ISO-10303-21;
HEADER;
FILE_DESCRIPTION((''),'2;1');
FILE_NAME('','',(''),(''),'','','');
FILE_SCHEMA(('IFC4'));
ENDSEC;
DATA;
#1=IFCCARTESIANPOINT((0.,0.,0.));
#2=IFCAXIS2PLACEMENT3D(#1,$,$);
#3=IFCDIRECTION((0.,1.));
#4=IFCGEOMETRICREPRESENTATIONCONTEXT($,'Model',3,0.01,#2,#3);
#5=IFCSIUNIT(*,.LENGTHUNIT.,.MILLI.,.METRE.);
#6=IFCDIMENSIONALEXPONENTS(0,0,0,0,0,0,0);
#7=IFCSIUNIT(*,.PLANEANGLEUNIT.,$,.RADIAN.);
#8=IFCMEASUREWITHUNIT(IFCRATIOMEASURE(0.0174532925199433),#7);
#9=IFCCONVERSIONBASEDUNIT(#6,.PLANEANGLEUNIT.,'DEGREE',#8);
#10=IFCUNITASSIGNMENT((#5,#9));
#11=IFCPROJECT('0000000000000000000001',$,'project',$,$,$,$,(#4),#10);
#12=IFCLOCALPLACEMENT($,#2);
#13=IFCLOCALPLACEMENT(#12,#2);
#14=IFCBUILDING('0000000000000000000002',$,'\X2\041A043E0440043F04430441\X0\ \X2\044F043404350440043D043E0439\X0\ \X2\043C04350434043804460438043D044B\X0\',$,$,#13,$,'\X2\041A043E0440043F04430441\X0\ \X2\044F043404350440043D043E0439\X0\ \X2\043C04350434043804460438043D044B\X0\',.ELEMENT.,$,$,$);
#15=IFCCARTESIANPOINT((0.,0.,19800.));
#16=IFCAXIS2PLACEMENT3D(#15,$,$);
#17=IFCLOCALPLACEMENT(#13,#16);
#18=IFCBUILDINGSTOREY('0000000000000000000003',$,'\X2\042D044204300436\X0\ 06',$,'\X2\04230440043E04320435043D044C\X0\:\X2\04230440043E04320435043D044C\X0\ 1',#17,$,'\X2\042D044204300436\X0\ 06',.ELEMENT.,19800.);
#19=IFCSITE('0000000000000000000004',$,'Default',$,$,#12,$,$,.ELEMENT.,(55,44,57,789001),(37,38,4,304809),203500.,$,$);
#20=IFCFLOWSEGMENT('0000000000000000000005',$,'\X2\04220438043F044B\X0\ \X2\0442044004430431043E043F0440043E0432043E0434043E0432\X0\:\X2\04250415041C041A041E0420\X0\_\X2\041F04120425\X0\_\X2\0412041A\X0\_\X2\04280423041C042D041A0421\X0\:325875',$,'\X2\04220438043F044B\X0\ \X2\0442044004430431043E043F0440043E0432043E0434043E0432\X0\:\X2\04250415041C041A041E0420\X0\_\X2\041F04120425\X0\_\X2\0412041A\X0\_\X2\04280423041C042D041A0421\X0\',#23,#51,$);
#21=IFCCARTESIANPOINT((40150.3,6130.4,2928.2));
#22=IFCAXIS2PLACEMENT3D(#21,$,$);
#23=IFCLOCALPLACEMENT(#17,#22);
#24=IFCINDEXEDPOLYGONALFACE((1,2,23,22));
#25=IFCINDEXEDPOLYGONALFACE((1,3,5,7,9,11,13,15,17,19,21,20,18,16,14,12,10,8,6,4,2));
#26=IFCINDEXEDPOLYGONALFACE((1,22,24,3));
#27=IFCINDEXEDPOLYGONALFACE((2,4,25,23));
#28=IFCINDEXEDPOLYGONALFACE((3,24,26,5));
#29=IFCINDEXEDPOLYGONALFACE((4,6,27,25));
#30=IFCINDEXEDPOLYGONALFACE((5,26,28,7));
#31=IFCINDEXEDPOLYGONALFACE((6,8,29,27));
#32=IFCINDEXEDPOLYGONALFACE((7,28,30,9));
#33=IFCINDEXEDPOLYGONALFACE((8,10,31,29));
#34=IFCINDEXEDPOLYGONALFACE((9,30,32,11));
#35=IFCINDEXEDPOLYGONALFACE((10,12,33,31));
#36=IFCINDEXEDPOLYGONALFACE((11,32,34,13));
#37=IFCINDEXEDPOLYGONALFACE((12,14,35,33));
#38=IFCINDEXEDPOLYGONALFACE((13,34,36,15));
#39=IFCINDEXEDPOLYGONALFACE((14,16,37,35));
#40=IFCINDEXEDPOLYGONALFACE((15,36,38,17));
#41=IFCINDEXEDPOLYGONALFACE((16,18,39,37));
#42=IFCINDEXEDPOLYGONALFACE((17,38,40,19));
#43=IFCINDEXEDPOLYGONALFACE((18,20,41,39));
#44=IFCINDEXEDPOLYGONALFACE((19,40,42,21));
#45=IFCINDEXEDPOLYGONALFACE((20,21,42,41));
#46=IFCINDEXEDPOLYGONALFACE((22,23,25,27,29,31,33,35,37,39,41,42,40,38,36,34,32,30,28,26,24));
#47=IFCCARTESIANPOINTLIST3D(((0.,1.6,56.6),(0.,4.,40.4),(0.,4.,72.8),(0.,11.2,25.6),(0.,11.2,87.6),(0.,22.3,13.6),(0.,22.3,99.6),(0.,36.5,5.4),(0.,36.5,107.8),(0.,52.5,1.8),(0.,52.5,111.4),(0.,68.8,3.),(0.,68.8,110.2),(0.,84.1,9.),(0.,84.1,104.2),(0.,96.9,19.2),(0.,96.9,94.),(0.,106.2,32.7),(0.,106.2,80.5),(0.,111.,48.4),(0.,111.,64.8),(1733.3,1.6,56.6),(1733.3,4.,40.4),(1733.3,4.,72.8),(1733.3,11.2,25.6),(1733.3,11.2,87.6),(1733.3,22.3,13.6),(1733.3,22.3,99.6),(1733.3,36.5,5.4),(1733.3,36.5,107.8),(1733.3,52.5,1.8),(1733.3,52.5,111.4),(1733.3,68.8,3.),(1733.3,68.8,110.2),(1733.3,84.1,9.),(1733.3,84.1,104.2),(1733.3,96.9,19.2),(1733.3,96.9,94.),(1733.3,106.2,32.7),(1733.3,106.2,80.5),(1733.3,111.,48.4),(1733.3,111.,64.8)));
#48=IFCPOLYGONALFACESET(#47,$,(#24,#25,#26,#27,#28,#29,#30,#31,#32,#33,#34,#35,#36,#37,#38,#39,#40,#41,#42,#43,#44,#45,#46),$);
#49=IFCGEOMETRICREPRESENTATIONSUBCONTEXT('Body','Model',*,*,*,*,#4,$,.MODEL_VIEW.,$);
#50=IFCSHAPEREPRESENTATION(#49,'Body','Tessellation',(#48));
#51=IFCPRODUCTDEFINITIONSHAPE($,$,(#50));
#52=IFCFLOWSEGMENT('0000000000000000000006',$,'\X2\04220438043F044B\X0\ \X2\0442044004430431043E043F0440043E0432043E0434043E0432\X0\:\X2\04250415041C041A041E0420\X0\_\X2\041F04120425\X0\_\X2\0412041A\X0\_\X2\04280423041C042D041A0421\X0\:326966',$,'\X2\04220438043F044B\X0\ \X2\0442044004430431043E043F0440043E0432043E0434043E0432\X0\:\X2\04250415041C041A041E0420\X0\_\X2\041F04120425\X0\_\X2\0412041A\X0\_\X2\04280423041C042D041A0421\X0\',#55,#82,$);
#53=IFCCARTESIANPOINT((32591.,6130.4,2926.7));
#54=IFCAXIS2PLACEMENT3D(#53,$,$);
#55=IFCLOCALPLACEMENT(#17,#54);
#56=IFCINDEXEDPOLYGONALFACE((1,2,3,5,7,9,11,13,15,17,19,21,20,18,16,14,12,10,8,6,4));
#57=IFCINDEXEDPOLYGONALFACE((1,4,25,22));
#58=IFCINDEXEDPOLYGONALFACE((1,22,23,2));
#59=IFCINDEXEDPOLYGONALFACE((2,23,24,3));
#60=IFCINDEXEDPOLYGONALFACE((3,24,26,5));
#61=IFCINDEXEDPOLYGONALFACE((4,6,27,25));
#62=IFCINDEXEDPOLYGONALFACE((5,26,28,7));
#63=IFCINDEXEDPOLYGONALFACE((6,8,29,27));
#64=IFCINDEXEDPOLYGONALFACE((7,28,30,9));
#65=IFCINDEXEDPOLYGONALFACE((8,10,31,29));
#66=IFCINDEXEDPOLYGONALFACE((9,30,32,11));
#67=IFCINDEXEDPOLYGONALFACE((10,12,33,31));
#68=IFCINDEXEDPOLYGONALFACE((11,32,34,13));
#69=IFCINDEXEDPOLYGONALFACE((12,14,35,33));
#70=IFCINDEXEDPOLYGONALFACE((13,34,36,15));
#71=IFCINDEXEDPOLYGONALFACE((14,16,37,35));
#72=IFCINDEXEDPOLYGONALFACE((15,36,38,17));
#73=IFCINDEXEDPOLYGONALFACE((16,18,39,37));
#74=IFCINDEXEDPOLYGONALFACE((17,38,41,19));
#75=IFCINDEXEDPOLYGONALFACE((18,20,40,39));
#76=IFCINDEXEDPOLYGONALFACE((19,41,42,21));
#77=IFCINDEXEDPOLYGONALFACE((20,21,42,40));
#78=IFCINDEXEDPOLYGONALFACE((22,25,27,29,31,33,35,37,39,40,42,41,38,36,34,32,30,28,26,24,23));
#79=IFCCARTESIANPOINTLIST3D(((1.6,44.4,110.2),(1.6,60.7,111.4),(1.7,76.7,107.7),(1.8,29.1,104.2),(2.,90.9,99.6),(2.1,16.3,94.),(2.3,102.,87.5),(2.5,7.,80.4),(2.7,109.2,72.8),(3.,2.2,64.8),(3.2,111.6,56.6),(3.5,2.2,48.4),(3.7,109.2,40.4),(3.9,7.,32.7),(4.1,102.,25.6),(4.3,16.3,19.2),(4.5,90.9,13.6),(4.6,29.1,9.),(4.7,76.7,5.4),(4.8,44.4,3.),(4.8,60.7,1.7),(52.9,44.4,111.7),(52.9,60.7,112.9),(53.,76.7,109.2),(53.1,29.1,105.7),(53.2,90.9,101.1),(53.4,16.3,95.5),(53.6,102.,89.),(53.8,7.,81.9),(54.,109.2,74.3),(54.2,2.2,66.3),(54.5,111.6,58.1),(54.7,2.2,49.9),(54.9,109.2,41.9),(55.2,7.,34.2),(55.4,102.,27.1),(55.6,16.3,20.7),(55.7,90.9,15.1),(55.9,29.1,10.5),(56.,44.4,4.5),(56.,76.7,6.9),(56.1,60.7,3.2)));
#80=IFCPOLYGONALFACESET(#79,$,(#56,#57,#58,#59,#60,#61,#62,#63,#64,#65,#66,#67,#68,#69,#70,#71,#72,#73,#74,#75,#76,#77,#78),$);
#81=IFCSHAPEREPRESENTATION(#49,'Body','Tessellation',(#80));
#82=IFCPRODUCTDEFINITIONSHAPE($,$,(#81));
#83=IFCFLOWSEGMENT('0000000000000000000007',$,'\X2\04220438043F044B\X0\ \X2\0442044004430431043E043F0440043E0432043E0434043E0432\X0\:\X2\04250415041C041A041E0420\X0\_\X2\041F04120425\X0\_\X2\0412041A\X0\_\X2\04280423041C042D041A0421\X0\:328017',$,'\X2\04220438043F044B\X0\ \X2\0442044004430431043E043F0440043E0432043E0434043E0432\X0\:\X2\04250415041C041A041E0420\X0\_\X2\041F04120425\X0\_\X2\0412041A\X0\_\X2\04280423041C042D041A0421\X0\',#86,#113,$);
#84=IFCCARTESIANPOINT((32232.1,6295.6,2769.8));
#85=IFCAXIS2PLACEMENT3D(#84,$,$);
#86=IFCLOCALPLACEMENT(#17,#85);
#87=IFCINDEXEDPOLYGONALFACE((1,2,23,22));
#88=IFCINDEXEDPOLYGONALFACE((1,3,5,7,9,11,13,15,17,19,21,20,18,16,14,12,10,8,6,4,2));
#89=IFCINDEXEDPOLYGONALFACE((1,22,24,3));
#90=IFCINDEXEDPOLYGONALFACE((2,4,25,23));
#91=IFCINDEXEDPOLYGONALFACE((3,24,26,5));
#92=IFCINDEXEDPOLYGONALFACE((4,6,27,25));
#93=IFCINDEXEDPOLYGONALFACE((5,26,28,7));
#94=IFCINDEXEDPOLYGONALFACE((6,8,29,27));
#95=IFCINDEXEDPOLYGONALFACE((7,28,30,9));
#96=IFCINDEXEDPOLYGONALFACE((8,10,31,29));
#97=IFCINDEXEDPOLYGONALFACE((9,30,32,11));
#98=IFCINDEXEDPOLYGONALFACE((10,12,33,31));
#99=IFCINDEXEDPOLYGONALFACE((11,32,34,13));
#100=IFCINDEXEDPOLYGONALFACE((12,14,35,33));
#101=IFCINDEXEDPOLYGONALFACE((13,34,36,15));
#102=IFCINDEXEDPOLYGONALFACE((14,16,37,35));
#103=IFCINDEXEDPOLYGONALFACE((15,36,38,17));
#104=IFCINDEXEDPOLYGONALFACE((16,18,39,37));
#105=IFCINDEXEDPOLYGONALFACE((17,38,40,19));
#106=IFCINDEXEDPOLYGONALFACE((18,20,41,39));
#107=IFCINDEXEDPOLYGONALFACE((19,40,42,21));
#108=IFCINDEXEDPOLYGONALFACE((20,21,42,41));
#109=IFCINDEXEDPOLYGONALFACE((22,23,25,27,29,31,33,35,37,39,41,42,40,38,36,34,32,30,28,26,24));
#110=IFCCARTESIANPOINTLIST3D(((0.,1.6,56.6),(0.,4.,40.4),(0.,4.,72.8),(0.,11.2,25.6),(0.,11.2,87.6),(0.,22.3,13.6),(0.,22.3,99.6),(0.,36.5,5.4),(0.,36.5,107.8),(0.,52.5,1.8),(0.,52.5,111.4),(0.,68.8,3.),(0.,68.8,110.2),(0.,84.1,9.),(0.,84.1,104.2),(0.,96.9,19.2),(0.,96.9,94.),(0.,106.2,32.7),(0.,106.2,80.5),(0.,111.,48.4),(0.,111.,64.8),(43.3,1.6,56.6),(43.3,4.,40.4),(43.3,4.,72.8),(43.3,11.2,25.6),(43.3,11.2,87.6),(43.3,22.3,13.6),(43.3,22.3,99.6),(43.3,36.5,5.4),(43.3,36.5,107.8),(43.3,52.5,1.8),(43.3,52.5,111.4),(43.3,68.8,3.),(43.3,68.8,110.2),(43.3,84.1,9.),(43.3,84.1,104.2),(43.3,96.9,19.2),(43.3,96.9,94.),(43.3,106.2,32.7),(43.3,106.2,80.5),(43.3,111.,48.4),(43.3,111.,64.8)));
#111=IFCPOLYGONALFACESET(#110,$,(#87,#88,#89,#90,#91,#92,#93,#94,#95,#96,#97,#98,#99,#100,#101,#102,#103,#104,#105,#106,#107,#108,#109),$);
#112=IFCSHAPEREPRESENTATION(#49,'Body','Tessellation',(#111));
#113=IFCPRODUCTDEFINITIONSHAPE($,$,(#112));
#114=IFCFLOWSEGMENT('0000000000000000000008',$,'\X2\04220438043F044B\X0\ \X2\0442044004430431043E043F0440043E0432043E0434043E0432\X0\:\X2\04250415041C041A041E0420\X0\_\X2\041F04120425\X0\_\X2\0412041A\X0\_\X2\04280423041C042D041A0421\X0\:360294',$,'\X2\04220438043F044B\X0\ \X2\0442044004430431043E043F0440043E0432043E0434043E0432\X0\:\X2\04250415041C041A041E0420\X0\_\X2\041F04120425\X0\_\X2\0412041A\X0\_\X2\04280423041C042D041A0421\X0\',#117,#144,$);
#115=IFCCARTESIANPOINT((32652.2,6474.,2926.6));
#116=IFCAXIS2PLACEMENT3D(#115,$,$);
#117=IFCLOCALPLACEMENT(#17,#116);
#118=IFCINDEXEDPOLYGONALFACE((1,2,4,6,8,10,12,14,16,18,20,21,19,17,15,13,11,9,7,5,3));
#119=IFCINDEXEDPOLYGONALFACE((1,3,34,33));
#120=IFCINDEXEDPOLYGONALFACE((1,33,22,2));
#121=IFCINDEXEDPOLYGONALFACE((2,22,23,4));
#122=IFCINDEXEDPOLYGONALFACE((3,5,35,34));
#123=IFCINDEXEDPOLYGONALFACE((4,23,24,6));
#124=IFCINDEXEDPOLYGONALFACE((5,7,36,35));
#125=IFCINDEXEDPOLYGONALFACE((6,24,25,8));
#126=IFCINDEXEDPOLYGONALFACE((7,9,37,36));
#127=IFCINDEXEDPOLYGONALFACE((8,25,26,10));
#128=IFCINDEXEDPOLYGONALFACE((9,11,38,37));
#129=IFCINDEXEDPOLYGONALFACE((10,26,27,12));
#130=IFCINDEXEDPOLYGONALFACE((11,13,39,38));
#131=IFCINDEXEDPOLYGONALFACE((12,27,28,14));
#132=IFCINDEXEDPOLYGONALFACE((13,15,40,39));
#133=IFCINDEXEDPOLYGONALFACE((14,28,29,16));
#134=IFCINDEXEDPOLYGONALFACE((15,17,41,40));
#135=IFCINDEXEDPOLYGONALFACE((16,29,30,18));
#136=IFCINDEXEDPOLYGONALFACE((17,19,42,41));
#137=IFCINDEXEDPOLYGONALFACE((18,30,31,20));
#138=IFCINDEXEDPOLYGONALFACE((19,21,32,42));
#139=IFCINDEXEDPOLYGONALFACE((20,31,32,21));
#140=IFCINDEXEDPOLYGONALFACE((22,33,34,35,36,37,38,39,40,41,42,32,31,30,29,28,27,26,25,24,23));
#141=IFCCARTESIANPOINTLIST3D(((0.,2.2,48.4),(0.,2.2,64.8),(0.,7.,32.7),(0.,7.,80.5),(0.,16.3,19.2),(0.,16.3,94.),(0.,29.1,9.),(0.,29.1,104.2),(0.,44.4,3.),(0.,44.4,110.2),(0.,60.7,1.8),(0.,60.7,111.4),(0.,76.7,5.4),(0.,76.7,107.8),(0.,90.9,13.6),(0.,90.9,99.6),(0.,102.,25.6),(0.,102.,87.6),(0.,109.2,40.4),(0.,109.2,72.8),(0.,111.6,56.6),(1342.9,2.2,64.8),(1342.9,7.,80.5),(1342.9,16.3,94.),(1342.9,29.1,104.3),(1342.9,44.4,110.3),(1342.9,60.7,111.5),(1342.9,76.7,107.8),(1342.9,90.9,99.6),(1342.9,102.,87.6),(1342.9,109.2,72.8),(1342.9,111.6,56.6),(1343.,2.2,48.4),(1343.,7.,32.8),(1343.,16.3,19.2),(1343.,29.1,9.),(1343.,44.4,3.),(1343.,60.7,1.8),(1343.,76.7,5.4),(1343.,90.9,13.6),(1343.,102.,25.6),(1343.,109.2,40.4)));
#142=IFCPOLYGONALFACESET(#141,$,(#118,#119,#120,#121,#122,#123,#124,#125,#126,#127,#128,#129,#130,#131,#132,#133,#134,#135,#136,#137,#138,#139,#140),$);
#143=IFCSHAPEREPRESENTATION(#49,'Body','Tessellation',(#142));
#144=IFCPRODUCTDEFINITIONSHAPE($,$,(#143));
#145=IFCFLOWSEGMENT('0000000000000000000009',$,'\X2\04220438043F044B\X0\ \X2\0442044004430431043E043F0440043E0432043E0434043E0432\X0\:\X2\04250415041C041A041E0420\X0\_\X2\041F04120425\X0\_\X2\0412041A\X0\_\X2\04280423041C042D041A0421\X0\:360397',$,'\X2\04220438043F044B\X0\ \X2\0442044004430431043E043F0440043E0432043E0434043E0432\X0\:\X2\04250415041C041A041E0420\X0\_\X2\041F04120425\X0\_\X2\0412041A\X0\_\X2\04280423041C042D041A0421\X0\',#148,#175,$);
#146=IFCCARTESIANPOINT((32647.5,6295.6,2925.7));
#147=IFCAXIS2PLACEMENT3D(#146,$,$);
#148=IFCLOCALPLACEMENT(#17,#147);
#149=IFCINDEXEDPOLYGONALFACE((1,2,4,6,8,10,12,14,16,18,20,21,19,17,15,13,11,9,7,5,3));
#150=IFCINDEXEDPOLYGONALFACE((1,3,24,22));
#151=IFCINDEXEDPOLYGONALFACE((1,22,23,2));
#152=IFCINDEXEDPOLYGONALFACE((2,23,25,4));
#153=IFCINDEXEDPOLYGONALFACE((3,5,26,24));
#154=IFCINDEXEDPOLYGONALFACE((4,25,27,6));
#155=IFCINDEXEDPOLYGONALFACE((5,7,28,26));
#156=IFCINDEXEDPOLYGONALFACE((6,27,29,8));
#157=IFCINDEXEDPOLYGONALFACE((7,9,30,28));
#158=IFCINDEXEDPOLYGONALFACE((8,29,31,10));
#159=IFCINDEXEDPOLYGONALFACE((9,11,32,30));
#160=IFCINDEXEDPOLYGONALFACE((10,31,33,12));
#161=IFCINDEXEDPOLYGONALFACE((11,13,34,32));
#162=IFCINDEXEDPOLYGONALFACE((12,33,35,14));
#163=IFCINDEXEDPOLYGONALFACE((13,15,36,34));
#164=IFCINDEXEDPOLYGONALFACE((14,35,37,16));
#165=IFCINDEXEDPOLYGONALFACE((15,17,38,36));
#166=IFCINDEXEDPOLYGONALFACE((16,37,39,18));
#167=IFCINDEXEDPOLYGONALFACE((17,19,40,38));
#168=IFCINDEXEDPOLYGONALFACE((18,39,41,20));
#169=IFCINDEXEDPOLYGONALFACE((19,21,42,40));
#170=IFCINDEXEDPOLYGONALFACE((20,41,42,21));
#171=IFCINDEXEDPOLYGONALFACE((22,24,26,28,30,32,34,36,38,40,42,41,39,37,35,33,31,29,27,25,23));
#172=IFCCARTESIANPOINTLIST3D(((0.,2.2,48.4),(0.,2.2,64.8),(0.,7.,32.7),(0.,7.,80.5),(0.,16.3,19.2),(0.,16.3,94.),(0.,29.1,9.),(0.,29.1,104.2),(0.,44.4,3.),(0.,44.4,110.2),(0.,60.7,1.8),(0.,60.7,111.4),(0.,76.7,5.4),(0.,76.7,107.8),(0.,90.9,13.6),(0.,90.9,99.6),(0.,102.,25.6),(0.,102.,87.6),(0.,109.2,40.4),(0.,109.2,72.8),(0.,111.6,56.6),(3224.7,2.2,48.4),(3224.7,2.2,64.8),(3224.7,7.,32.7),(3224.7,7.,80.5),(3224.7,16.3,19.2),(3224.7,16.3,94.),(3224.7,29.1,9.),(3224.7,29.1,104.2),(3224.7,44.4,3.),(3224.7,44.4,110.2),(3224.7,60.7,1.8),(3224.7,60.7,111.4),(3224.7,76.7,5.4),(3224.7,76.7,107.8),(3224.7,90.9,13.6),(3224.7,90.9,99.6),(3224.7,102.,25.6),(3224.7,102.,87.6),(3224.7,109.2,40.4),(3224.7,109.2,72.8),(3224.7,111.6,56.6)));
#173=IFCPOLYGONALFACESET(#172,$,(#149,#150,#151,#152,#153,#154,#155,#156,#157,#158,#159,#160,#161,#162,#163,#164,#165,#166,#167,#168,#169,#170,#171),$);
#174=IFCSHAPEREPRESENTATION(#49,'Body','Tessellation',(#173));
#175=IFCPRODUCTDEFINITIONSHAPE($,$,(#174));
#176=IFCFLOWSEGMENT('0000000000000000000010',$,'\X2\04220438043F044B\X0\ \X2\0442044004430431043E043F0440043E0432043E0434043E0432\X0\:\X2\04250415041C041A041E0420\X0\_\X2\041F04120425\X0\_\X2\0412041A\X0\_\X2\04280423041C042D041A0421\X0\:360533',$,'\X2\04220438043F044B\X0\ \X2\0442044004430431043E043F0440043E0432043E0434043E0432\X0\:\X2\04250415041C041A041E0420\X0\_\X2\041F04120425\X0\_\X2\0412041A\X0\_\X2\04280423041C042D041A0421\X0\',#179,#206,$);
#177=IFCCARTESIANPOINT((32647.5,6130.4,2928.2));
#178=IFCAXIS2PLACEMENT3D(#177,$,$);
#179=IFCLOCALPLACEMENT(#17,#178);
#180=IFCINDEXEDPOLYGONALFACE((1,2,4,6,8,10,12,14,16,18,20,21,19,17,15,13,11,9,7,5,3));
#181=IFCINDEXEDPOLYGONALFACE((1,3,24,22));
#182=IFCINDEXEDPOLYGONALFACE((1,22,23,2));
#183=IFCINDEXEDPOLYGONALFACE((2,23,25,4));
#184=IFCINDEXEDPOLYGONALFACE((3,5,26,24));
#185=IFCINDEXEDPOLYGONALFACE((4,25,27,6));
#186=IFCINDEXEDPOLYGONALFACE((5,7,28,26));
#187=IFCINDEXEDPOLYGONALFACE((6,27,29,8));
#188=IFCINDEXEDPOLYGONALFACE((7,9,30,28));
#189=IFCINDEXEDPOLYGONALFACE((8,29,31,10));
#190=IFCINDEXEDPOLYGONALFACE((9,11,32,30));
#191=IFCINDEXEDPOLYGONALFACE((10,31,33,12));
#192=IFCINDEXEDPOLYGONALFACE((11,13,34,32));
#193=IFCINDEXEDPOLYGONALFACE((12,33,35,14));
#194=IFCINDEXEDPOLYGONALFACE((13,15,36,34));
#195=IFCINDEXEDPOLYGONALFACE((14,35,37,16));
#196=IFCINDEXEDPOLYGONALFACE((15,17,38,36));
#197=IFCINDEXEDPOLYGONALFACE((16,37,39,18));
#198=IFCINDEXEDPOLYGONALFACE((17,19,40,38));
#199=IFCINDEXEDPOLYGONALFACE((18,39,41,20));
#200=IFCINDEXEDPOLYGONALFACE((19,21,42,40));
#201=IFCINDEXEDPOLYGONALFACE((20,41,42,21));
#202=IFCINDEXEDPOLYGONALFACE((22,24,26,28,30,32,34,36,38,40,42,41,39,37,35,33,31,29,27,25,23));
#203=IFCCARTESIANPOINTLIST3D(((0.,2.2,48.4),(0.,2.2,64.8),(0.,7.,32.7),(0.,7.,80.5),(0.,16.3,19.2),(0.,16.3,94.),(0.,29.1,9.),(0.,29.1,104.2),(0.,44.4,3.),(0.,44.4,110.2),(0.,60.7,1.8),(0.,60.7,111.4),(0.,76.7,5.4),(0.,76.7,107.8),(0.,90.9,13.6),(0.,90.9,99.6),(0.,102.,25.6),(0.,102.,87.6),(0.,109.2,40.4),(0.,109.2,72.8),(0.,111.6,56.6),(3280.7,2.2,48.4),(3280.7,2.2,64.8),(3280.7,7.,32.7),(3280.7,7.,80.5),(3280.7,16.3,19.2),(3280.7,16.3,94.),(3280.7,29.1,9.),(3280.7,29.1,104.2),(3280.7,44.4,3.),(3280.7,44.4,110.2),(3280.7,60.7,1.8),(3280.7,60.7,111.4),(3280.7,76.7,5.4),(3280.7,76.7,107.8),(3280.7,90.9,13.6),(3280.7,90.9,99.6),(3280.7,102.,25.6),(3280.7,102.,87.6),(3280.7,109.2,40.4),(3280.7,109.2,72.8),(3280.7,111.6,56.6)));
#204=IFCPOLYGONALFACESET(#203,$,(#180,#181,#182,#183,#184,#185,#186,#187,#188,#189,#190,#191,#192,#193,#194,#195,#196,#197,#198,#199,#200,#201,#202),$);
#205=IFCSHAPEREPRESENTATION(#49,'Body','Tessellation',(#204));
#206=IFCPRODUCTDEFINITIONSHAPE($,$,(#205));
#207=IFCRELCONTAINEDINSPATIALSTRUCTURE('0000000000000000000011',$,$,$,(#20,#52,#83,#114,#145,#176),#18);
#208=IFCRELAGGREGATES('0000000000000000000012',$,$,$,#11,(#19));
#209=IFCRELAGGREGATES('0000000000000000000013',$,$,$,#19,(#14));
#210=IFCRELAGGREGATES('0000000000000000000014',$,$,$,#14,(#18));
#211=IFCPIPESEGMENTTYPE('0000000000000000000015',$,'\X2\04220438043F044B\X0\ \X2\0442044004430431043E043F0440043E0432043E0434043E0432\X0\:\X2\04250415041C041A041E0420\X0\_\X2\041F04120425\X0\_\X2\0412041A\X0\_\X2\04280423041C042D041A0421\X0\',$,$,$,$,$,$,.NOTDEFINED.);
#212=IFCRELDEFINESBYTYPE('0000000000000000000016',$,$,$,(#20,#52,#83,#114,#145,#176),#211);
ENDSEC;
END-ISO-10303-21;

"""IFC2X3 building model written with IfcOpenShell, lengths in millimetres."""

from ifc_helpers import new_model, entity, si_unit, converted_unit, direction, frame, origin, origin_2d_with_axis, place, context, subcontext, project, spatial, circle, extrude, type_object, element, save


model = new_model("IFC2X3")

# Units and contexts
model_context = context("Model", 3, precision=0.01, world=origin(), true_north=direction((0.0, 1.0)))
body_context = subcontext(model_context, "Body", "Model", "MODEL_VIEW")
ifc_project = project(units=[si_unit("LENGTHUNIT", "METRE", prefix="MILLI"), converted_unit("PLANEANGLEUNIT", "DEGREE", entity("IfcRatioMeasure", 0.0174532925199433), si_unit("PLANEANGLEUNIT", "RADIAN"), dimensions=[0, 0, 0, 0, 0, 0, 0])], contexts=[model_context])

# Site, building, storey
site_placement = place(None, origin())
site = spatial("IfcSite", under=ifc_project, at=site_placement, Name="Default", CompositionType="ELEMENT", RefLatitude=(55, 44, 57, 789001), RefLongitude=(37, 38, 4, 304809), RefElevation=203500.0)
building_placement = place(site_placement, origin())
building = spatial("IfcBuilding", under=site, at=building_placement, Name="Корпус ядерной медицины", LongName="Корпус ядерной медицины", CompositionType="ELEMENT")
storey_placement = place(building_placement, frame((0.0, 0.0, 19800.0)))
storey = spatial("IfcBuildingStorey", under=building, at=storey_placement, Name="Этаж 06", ObjectType="Уровень:Уровень 1", LongName="Этаж 06", CompositionType="ELEMENT", Elevation=19800.0)

# Flow segments
pipe_segment_type = type_object("IfcPipeSegmentType", Name="Типы трубопроводов:ХЕМКОР_ПВХ_ВК_ШУМЭКС", PredefinedType="NOTDEFINED")
flow_segment_1_placement = place(storey_placement, frame((40150.3, 6130.4, 2928.2)))
element("IfcFlowSegment", 1, at=flow_segment_1_placement, inside=storey, type_object=pipe_segment_type, Name="Типы трубопроводов:ХЕМКОР_ПВХ_ВК_ШУМЭКС:325875", ObjectType="Типы трубопроводов:ХЕМКОР_ПВХ_ВК_ШУМЭКС", context=body_context, shape_type="SweptSolid", body=[
    extrude(circle(Radius=55.0, at=origin_2d_with_axis()), frame((0.0, 56.6, 56.6), z_axis=(1.0, 0.0, 0.0), x_axis=(0.0, -1.0, 0.0)), (0.0, 0.0, 1.0), 1733.3),
])
flow_segment_2_placement = place(storey_placement, frame((32591.0, 6130.4, 2926.7)))
element("IfcFlowSegment", 2, at=flow_segment_2_placement, inside=storey, type_object=pipe_segment_type, Name="Типы трубопроводов:ХЕМКОР_ПВХ_ВК_ШУМЭКС:326966", ObjectType="Типы трубопроводов:ХЕМКОР_ПВХ_ВК_ШУМЭКС", context=body_context, shape_type="SweptSolid", body=[
    extrude(circle(Radius=55.0, at=origin_2d_with_axis()), frame((3.2, 56.6, 56.6), z_axis=(0.999571, 0.0, 0.029297), x_axis=(0.0, 1.0, 0.0)), (0.0, 0.0, 1.0), 51.3),
])
flow_segment_3_placement = place(storey_placement, frame((32232.1, 6295.6, 2769.8)))
element("IfcFlowSegment", 3, at=flow_segment_3_placement, inside=storey, type_object=pipe_segment_type, Name="Типы трубопроводов:ХЕМКОР_ПВХ_ВК_ШУМЭКС:328017", ObjectType="Типы трубопроводов:ХЕМКОР_ПВХ_ВК_ШУМЭКС", context=body_context, shape_type="SweptSolid", body=[
    extrude(circle(Radius=55.0, at=origin_2d_with_axis()), frame((0.0, 56.6, 56.6), z_axis=(1.0, 0.0, 0.0), x_axis=(0.0, -1.0, 0.0)), (0.0, 0.0, 1.0), 43.3),
])
flow_segment_4_placement = place(storey_placement, frame((32652.2, 6474.0, 2926.6)))
element("IfcFlowSegment", 4, at=flow_segment_4_placement, inside=storey, type_object=pipe_segment_type, Name="Типы трубопроводов:ХЕМКОР_ПВХ_ВК_ШУМЭКС:360294", ObjectType="Типы трубопроводов:ХЕМКОР_ПВХ_ВК_ШУМЭКС", context=body_context, shape_type="SweptSolid", body=[
    extrude(circle(Radius=55.0, at=origin_2d_with_axis()), frame((0.0, 56.6, 56.6), z_axis=(1.0, 0.0, 0.000022), x_axis=(0.0, 1.0, 0.0)), (0.0, 0.0, 1.0), 1342.9),
])
flow_segment_5_placement = place(storey_placement, frame((32647.5, 6295.6, 2925.7)))
element("IfcFlowSegment", 5, at=flow_segment_5_placement, inside=storey, type_object=pipe_segment_type, Name="Типы трубопроводов:ХЕМКОР_ПВХ_ВК_ШУМЭКС:360397", ObjectType="Типы трубопроводов:ХЕМКОР_ПВХ_ВК_ШУМЭКС", context=body_context, shape_type="SweptSolid", body=[
    extrude(circle(Radius=55.0, at=origin_2d_with_axis()), frame((0.0, 56.6, 56.6), z_axis=(1.0, 0.0, 0.0), x_axis=(0.0, 1.0, 0.0)), (0.0, 0.0, 1.0), 3224.7),
])
flow_segment_6_placement = place(storey_placement, frame((32647.5, 6130.4, 2928.2)))
element("IfcFlowSegment", 6, at=flow_segment_6_placement, inside=storey, type_object=pipe_segment_type, Name="Типы трубопроводов:ХЕМКОР_ПВХ_ВК_ШУМЭКС:360533", ObjectType="Типы трубопроводов:ХЕМКОР_ПВХ_ВК_ШУМЭКС", context=body_context, shape_type="SweptSolid", body=[
    extrude(circle(Radius=55.0, at=origin_2d_with_axis()), frame((0.0, 56.6, 56.6), z_axis=(1.0, 0.0, 0.0), x_axis=(0.0, 1.0, 0.0)), (0.0, 0.0, 1.0), 3280.7),
])

save(model, "model.ifc")
